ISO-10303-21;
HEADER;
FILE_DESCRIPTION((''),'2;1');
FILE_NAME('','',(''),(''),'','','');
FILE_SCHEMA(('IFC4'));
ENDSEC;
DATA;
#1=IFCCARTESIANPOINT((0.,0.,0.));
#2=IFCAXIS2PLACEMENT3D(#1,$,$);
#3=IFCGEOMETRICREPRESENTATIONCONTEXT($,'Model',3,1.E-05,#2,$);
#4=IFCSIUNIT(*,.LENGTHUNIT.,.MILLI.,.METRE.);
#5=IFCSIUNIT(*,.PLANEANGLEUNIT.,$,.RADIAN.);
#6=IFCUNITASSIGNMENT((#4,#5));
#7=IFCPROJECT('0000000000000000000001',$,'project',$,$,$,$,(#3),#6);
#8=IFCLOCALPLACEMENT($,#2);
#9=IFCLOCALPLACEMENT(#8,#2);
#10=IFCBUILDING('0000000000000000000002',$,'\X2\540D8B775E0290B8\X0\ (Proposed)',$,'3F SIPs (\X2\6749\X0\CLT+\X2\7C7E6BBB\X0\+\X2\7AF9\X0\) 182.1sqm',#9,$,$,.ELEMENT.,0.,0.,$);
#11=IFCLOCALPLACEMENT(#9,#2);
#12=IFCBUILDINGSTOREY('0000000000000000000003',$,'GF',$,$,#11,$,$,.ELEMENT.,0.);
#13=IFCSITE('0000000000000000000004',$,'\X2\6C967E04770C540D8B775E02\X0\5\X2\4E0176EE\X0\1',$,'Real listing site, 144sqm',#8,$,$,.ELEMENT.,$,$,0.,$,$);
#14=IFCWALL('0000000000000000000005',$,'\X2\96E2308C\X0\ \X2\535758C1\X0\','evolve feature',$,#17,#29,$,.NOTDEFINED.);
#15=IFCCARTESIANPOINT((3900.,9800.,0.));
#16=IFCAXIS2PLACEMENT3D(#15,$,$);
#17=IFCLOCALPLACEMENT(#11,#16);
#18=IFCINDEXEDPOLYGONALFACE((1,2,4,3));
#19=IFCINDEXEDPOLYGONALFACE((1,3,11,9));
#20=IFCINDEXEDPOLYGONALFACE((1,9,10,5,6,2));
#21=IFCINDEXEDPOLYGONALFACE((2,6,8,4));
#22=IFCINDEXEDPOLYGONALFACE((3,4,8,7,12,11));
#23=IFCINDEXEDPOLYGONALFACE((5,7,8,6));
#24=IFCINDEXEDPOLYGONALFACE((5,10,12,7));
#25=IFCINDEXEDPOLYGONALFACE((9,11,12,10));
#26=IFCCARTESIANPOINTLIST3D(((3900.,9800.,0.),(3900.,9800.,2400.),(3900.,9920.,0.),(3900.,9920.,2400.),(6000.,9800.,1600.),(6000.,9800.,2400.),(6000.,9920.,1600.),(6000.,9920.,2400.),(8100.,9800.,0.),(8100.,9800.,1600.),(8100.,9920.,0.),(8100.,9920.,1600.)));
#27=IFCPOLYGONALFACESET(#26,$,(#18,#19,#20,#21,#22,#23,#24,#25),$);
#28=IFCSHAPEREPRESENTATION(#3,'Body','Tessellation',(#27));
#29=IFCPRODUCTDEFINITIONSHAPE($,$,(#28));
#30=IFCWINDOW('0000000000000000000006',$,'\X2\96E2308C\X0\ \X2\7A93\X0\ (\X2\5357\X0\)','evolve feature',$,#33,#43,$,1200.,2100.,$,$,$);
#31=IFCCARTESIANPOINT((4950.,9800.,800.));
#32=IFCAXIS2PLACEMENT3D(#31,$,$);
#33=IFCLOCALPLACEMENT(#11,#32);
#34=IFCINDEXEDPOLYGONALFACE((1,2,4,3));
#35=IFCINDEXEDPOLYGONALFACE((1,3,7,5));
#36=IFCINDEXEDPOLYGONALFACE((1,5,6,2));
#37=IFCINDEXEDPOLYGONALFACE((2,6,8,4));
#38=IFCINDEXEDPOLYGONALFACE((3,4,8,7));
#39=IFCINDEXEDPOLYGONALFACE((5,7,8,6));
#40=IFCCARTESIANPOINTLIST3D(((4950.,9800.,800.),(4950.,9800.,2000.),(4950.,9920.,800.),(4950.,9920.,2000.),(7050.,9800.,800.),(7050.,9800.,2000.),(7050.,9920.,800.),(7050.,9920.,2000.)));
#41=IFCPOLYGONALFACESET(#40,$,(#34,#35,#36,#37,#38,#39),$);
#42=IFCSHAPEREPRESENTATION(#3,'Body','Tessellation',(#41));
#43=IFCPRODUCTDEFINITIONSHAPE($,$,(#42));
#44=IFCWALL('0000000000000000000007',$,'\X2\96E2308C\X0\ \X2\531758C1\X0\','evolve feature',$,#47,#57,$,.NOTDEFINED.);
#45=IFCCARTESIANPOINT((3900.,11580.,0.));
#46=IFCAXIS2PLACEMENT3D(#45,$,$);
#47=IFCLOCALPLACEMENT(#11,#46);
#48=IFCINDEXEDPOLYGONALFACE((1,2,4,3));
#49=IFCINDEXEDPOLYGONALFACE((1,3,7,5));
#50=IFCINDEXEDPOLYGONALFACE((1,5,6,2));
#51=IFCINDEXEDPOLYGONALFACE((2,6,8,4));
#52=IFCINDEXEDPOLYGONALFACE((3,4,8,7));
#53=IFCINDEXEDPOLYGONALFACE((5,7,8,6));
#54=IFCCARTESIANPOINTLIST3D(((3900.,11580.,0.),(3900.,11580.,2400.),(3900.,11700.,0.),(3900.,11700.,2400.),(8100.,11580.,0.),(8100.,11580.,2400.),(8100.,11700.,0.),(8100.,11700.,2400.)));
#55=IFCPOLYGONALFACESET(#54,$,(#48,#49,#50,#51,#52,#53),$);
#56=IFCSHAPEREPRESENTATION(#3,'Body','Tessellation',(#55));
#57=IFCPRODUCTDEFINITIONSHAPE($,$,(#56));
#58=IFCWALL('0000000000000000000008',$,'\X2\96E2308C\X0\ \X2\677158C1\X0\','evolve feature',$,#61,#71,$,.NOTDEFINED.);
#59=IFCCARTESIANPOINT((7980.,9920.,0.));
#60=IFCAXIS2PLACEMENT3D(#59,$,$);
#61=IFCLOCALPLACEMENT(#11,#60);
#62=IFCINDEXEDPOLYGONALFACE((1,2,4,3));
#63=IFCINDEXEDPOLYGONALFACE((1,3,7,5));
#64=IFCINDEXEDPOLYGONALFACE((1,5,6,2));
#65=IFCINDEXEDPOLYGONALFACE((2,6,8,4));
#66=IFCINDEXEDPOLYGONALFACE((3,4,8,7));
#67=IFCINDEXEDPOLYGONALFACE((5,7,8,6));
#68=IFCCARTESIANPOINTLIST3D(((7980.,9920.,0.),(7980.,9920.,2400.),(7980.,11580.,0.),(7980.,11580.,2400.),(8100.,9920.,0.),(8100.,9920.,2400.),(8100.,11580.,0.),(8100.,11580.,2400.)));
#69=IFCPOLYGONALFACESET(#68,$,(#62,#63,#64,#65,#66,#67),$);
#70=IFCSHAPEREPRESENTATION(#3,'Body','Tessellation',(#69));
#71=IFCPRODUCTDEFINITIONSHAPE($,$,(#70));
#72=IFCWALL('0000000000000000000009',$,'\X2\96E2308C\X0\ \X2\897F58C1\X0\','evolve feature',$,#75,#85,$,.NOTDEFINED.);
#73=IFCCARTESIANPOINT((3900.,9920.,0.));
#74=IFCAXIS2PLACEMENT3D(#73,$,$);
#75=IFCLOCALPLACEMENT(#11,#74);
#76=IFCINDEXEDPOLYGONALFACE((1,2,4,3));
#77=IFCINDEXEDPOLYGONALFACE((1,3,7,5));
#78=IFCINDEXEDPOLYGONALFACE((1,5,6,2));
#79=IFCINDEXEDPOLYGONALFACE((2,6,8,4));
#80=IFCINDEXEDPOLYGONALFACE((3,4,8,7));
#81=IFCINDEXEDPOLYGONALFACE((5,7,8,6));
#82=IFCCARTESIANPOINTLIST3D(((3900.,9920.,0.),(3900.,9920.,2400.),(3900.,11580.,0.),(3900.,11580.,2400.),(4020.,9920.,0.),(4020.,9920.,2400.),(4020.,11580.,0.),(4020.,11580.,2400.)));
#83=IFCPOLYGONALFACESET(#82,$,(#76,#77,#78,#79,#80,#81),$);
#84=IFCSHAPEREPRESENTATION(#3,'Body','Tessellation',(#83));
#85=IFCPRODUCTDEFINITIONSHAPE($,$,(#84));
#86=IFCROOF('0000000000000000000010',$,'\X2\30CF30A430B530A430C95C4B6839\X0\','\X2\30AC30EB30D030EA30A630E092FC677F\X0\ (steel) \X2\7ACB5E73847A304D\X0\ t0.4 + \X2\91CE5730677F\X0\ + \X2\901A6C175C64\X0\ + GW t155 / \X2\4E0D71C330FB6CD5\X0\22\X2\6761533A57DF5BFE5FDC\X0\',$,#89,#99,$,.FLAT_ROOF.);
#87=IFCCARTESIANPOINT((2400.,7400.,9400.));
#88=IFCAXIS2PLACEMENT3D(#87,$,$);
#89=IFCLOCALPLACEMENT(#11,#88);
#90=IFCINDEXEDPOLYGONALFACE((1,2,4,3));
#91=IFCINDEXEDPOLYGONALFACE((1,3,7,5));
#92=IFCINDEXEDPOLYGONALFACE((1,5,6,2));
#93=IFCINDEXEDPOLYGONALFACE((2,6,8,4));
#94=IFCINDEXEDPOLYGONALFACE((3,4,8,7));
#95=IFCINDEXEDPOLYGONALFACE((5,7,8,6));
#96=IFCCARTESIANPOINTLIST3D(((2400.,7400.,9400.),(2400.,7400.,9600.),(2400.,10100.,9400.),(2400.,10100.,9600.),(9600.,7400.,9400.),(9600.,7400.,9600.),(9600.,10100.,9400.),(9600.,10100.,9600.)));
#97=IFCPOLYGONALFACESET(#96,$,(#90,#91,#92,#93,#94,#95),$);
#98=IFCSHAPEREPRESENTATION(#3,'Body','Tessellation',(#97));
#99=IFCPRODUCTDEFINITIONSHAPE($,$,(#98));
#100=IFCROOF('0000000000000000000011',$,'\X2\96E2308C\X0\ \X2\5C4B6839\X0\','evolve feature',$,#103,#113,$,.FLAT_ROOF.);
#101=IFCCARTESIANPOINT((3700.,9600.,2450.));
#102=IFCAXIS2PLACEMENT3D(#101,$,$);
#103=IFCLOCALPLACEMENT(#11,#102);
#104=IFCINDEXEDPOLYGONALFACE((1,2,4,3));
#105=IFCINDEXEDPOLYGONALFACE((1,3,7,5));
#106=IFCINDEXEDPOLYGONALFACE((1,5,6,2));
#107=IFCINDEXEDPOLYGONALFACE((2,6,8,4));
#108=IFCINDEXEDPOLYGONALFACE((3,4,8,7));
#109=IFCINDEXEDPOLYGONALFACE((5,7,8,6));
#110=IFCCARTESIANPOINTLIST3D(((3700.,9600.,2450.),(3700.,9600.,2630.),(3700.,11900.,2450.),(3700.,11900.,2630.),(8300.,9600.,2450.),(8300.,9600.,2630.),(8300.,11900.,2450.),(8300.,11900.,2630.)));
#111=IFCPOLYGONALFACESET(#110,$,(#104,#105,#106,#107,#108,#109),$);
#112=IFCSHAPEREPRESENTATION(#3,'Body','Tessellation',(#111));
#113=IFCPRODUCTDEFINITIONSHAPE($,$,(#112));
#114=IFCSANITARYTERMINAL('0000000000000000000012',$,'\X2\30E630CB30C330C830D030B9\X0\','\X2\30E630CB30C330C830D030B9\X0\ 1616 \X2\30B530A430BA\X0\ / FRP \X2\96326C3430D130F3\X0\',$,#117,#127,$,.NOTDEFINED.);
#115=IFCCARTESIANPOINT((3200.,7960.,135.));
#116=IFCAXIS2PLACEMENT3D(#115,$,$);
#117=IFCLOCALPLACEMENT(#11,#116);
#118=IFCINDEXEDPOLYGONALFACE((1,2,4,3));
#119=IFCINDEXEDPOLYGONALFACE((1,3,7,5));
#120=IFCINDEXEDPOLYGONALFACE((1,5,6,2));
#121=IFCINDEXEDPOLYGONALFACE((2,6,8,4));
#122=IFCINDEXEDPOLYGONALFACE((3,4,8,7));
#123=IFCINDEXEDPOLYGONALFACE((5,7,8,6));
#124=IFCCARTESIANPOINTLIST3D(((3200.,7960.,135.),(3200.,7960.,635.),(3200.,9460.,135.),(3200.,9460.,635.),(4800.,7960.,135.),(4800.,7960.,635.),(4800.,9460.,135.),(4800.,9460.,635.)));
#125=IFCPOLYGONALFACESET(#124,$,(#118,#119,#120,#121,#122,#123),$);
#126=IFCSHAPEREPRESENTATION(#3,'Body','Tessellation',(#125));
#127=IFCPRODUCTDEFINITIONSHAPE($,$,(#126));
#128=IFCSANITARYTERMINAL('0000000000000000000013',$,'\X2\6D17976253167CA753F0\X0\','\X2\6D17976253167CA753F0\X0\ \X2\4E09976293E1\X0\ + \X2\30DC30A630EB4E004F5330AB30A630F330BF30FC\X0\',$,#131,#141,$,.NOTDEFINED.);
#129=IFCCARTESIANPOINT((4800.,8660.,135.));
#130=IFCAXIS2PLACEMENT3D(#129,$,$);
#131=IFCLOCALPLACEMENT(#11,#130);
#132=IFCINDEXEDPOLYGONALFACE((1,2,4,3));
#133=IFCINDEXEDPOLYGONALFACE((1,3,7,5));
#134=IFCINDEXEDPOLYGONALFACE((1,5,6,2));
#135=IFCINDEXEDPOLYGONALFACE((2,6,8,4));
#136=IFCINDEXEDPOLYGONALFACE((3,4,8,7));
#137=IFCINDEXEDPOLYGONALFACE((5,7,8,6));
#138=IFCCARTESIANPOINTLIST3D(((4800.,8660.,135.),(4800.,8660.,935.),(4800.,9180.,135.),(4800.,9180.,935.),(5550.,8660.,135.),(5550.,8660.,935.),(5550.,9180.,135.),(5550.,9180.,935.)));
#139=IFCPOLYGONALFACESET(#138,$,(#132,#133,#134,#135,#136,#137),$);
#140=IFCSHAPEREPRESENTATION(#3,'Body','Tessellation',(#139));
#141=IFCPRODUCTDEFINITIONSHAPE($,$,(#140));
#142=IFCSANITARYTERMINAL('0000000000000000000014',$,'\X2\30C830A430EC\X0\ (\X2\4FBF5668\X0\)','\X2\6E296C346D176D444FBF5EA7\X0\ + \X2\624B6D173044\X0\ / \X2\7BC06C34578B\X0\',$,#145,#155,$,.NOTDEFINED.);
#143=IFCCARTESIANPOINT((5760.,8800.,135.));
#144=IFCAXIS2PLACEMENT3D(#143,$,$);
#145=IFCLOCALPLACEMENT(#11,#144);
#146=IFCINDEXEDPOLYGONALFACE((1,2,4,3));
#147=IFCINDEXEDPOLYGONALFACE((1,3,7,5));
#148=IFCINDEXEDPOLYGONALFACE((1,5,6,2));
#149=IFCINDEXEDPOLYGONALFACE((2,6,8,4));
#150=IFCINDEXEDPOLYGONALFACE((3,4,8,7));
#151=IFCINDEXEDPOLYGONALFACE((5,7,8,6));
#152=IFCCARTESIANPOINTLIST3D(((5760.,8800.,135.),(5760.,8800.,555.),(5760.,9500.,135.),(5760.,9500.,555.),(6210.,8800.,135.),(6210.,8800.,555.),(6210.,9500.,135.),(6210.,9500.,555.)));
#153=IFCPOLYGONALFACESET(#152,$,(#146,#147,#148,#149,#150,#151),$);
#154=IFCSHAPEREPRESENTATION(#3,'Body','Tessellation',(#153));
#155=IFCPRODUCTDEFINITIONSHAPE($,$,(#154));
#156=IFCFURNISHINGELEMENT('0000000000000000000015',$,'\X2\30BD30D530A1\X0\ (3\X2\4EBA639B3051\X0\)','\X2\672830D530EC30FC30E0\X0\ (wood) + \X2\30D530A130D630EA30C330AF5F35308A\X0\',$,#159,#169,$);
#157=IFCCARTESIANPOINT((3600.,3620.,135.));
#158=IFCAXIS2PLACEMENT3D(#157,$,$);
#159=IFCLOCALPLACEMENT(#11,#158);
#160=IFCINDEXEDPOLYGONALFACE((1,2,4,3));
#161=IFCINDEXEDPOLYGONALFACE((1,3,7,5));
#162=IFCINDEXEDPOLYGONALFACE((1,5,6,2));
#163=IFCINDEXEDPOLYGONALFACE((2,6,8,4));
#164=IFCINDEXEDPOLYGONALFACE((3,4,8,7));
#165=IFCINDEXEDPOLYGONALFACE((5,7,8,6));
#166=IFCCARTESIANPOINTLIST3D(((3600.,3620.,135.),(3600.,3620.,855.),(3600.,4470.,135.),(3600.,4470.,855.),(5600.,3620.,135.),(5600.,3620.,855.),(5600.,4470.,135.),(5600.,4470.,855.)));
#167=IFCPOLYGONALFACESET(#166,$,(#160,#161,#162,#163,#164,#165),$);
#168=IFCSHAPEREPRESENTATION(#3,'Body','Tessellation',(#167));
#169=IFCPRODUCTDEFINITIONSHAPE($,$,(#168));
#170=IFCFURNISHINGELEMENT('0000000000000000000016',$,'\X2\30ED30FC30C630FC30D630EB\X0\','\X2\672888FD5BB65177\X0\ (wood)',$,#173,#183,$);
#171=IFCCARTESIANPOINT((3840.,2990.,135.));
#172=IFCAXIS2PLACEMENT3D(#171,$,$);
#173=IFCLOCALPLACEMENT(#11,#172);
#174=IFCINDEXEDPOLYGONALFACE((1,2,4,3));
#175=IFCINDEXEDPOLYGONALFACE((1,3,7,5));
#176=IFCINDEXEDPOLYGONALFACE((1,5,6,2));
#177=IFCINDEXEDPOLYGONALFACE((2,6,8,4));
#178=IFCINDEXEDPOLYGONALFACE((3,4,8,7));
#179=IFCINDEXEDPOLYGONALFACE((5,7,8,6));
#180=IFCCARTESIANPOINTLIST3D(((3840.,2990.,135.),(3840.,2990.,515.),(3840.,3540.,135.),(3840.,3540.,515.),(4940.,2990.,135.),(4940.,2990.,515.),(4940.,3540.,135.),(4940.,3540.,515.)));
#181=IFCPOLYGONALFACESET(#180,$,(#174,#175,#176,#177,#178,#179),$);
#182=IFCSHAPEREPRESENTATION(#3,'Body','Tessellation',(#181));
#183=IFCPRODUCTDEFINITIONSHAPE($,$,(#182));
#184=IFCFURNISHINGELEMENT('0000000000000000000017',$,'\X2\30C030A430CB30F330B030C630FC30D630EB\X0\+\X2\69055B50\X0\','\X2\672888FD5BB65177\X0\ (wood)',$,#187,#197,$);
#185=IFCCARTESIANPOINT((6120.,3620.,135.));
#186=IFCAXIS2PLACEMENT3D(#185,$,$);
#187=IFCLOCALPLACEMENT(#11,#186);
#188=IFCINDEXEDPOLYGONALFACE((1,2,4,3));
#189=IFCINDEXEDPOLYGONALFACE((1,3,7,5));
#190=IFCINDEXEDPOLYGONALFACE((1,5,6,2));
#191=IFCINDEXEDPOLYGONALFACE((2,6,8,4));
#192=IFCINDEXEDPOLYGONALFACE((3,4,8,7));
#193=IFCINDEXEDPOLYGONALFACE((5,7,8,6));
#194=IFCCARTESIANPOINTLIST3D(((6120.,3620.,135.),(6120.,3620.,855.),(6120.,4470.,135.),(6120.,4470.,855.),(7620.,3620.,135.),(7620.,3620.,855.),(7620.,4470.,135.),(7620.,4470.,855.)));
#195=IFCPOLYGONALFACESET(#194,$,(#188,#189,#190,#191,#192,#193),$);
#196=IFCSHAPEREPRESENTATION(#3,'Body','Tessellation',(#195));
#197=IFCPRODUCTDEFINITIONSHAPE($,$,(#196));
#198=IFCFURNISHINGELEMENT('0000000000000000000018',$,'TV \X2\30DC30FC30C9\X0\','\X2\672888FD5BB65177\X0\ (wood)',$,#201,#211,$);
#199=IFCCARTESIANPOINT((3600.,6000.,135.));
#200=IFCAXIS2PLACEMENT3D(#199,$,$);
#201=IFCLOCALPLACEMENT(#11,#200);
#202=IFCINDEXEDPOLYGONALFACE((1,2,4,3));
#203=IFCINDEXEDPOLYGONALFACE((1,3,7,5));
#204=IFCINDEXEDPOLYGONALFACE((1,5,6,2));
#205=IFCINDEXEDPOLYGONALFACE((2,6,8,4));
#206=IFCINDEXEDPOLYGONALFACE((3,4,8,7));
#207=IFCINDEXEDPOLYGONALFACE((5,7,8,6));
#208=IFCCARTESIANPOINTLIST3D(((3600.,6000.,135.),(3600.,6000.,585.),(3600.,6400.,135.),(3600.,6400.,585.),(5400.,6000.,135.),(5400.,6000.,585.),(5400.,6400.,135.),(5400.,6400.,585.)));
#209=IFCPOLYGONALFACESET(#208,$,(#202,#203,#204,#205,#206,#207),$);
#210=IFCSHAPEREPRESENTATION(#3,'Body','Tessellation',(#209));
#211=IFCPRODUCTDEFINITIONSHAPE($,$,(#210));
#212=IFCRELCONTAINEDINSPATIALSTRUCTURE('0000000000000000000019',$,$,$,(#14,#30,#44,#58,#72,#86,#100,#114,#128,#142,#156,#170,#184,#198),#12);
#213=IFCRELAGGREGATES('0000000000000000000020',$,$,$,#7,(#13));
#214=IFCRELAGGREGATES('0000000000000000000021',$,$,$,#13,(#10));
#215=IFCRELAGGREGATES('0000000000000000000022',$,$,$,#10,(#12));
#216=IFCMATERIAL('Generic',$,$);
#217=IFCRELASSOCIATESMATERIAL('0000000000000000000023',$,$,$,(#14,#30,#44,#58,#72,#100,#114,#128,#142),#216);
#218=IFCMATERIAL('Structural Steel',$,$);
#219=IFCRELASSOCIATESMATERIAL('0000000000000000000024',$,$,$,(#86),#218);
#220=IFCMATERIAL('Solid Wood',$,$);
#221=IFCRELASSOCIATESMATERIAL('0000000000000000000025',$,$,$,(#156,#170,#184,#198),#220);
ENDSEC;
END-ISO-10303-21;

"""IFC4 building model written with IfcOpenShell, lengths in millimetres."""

from ifc_helpers import new_model, si_unit, frame, frame_2d, origin, place, context, project, spatial, rectangle, extrude, material, element, fill, save


model = new_model("IFC4")

# Units and contexts
model_context = context("Model", 3, precision=1e-05, world=origin())
ifc_project = project(units=[si_unit("LENGTHUNIT", "METRE", prefix="MILLI"), si_unit("PLANEANGLEUNIT", "RADIAN")], contexts=[model_context])

# Site, building, storey
site_placement = place(None, origin())
site = spatial("IfcSite", under=ifc_project, at=site_placement, Name="沖縄県名護市5丁目1", ObjectType="Real listing site, 144sqm", CompositionType="ELEMENT", RefElevation=0.0)
building_placement = place(site_placement, origin())
building = spatial("IfcBuilding", under=site, at=building_placement, Name="名護市邸 (Proposed)", ObjectType="3F SIPs (杉CLT+籾殻+竹) 182.1sqm", CompositionType="ELEMENT", ElevationOfRefHeight=0.0, ElevationOfTerrain=0.0)
storey_placement = place(building_placement, origin())
storey = spatial("IfcBuildingStorey", under=building, at=storey_placement, Name="GF", CompositionType="ELEMENT", Elevation=0.0)

# Shared definitions
ifc_material_1 = material(Name="Generic")

# Shared definitions
ifc_material_2 = material(Name="Solid Wood")

# Wall, opening, window
wall_1_placement = place(storey_placement, frame((3900.0, 9800.0, 0.0)))
wall_1 = element("IfcWall", 1, at=wall_1_placement, inside=storey, material=ifc_material_1, Name="離れ 南壁", Description="evolve feature", PredefinedType="NOTDEFINED", context=model_context, shape_type="SweptSolid", body=[
    extrude(rectangle(XDim=4200.0, YDim=120.0, at=frame_2d((2100.0, 60.0))), frame((3900.0, 9800.0, 0.0)), (0.0, 0.0, 1.0), 2400.0),
])
opening_1_placement = place(storey_placement, frame((4950.0, 9800.0, 800.0)))
opening_1 = element("IfcOpeningElement", 2, at=opening_1_placement, cuts=wall_1, PredefinedType="NOTDEFINED", context=model_context, shape_type="SweptSolid", body=[
    extrude(rectangle(XDim=2100.0, YDim=120.0, at=frame_2d((1050.0, 60.0))), frame((4950.0, 9800.0, 800.0)), (0.0, 0.0, 1.0), 1200.0),
])
window_1_placement = place(storey_placement, frame((4950.0, 9800.0, 800.0)))
window_1 = element("IfcWindow", 3, at=window_1_placement, inside=storey, material=ifc_material_1, Name="離れ 窓 (南)", Description="evolve feature", OverallHeight=1200.0, OverallWidth=2100.0, context=model_context, shape_type="SweptSolid", body=[
    extrude(rectangle(XDim=2100.0, YDim=120.0, at=frame_2d((1050.0, 60.0))), frame((4950.0, 9800.0, 800.0)), (0.0, 0.0, 1.0), 1200.0),
])
fill(opening_1, window_1)

# Walls
wall_2_placement = place(storey_placement, frame((3900.0, 11580.0, 0.0)))
element("IfcWall", 4, at=wall_2_placement, inside=storey, material=ifc_material_1, Name="離れ 北壁", Description="evolve feature", PredefinedType="NOTDEFINED", context=model_context, shape_type="SweptSolid", body=[
    extrude(rectangle(XDim=4200.0, YDim=120.0, at=frame_2d((2100.0, 60.0))), frame((3900.0, 11580.0, 0.0)), (0.0, 0.0, 1.0), 2400.0),
])
wall_3_placement = place(storey_placement, frame((7980.0, 9920.0, 0.0)))
element("IfcWall", 5, at=wall_3_placement, inside=storey, material=ifc_material_1, Name="離れ 東壁", Description="evolve feature", PredefinedType="NOTDEFINED", context=model_context, shape_type="SweptSolid", body=[
    extrude(rectangle(XDim=120.0, YDim=1660.0, at=frame_2d((60.0, 830.0))), frame((7980.0, 9920.0, 0.0)), (0.0, 0.0, 1.0), 2400.0),
])
wall_4_placement = place(storey_placement, frame((3900.0, 9920.0, 0.0)))
element("IfcWall", 6, at=wall_4_placement, inside=storey, material=ifc_material_1, Name="離れ 西壁", Description="evolve feature", PredefinedType="NOTDEFINED", context=model_context, shape_type="SweptSolid", body=[
    extrude(rectangle(XDim=120.0, YDim=1660.0, at=frame_2d((60.0, 830.0))), frame((3900.0, 9920.0, 0.0)), (0.0, 0.0, 1.0), 2400.0),
])

# Roofs
ifc_material_3 = material(Name="Structural Steel")
roof_1_placement = place(storey_placement, frame((2400.0, 7400.0, 9400.0)))
element("IfcRoof", 7, at=roof_1_placement, inside=storey, material=ifc_material_3, Name="ハイサイド屋根", Description="ガルバリウム鋼板 (steel) 立平葺き t0.4 + 野地板 + 通気層 + GW t155 / 不燃・法22条区域対応", PredefinedType="FLAT_ROOF", context=model_context, shape_type="SweptSolid", body=[
    extrude(rectangle(XDim=7200.0, YDim=2700.0, at=frame_2d((3600.0, 1350.0))), frame((2400.0, 7400.0, 9400.0)), (0.0, 0.0, 1.0), 200.0),
])
roof_2_placement = place(storey_placement, frame((3700.0, 9600.0, 2450.0)))
element("IfcRoof", 8, at=roof_2_placement, inside=storey, material=ifc_material_1, Name="離れ 屋根", Description="evolve feature", PredefinedType="FLAT_ROOF", context=model_context, shape_type="SweptSolid", body=[
    extrude(rectangle(XDim=4600.0, YDim=2300.0, at=frame_2d((2300.0, 1150.0))), frame((3700.0, 9600.0, 2450.0)), (0.0, 0.0, 1.0), 180.0),
])

# Sanitary terminals
sanitary_terminal_1_placement = place(storey_placement, frame((3200.0, 7960.0, 135.0)))
element("IfcSanitaryTerminal", 9, at=sanitary_terminal_1_placement, inside=storey, material=ifc_material_1, Name="ユニットバス", Description="ユニットバス 1616 サイズ / FRP 防水パン", PredefinedType="NOTDEFINED", context=model_context, shape_type="SweptSolid", body=[
    extrude(rectangle(XDim=1600.0, YDim=1500.0, at=frame_2d((800.0, 750.0))), frame((3200.0, 7960.0, 135.0)), (0.0, 0.0, 1.0), 500.0),
])
sanitary_terminal_2_placement = place(storey_placement, frame((4800.0, 8660.0, 135.0)))
element("IfcSanitaryTerminal", 10, at=sanitary_terminal_2_placement, inside=storey, material=ifc_material_1, Name="洗面化粧台", Description="洗面化粧台 三面鏡 + ボウル一体カウンター", PredefinedType="NOTDEFINED", context=model_context, shape_type="SweptSolid", body=[
    extrude(rectangle(XDim=750.0, YDim=520.0, at=frame_2d((375.0, 260.0))), frame((4800.0, 8660.0, 135.0)), (0.0, 0.0, 1.0), 800.0),
])
sanitary_terminal_3_placement = place(storey_placement, frame((5760.0, 8800.0, 135.0)))
element("IfcSanitaryTerminal", 11, at=sanitary_terminal_3_placement, inside=storey, material=ifc_material_1, Name="トイレ (便器)", Description="温水洗浄便座 + 手洗い / 節水型", PredefinedType="NOTDEFINED", context=model_context, shape_type="SweptSolid", body=[
    extrude(rectangle(XDim=450.0, YDim=700.0, at=frame_2d((225.0, 350.0))), frame((5760.0, 8800.0, 135.0)), (0.0, 0.0, 1.0), 420.0),
])

# Furnishing elements
furnishing_1_placement = place(storey_placement, frame((3600.0, 3620.0, 135.0)))
element("IfcFurnishingElement", 12, at=furnishing_1_placement, inside=storey, material=ifc_material_2, Name="ソファ (3人掛け)", Description="木フレーム (wood) + ファブリック張り", context=model_context, shape_type="SweptSolid", body=[
    extrude(rectangle(XDim=2000.0, YDim=850.0, at=frame_2d((1000.0, 425.0))), frame((3600.0, 3620.0, 135.0)), (0.0, 0.0, 1.0), 720.0),
])
furnishing_2_placement = place(storey_placement, frame((3840.0, 2990.0, 135.0)))
element("IfcFurnishingElement", 13, at=furnishing_2_placement, inside=storey, material=ifc_material_2, Name="ローテーブル", Description="木製家具 (wood)", context=model_context, shape_type="SweptSolid", body=[
    extrude(rectangle(XDim=1100.0, YDim=550.0, at=frame_2d((550.0, 275.0))), frame((3840.0, 2990.0, 135.0)), (0.0, 0.0, 1.0), 380.0),
])
furnishing_3_placement = place(storey_placement, frame((6120.0, 3620.0, 135.0)))
element("IfcFurnishingElement", 14, at=furnishing_3_placement, inside=storey, material=ifc_material_2, Name="ダイニングテーブル+椅子", Description="木製家具 (wood)", context=model_context, shape_type="SweptSolid", body=[
    extrude(rectangle(XDim=1500.0, YDim=850.0, at=frame_2d((750.0, 425.0))), frame((6120.0, 3620.0, 135.0)), (0.0, 0.0, 1.0), 720.0),
])
furnishing_4_placement = place(storey_placement, frame((3600.0, 6000.0, 135.0)))
element("IfcFurnishingElement", 15, at=furnishing_4_placement, inside=storey, material=ifc_material_2, Name="TV ボード", Description="木製家具 (wood)", context=model_context, shape_type="SweptSolid", body=[
    extrude(rectangle(XDim=1800.0, YDim=400.0, at=frame_2d((900.0, 200.0))), frame((3600.0, 6000.0, 135.0)), (0.0, 0.0, 1.0), 450.0),
])

save(model, "model.ifc")
